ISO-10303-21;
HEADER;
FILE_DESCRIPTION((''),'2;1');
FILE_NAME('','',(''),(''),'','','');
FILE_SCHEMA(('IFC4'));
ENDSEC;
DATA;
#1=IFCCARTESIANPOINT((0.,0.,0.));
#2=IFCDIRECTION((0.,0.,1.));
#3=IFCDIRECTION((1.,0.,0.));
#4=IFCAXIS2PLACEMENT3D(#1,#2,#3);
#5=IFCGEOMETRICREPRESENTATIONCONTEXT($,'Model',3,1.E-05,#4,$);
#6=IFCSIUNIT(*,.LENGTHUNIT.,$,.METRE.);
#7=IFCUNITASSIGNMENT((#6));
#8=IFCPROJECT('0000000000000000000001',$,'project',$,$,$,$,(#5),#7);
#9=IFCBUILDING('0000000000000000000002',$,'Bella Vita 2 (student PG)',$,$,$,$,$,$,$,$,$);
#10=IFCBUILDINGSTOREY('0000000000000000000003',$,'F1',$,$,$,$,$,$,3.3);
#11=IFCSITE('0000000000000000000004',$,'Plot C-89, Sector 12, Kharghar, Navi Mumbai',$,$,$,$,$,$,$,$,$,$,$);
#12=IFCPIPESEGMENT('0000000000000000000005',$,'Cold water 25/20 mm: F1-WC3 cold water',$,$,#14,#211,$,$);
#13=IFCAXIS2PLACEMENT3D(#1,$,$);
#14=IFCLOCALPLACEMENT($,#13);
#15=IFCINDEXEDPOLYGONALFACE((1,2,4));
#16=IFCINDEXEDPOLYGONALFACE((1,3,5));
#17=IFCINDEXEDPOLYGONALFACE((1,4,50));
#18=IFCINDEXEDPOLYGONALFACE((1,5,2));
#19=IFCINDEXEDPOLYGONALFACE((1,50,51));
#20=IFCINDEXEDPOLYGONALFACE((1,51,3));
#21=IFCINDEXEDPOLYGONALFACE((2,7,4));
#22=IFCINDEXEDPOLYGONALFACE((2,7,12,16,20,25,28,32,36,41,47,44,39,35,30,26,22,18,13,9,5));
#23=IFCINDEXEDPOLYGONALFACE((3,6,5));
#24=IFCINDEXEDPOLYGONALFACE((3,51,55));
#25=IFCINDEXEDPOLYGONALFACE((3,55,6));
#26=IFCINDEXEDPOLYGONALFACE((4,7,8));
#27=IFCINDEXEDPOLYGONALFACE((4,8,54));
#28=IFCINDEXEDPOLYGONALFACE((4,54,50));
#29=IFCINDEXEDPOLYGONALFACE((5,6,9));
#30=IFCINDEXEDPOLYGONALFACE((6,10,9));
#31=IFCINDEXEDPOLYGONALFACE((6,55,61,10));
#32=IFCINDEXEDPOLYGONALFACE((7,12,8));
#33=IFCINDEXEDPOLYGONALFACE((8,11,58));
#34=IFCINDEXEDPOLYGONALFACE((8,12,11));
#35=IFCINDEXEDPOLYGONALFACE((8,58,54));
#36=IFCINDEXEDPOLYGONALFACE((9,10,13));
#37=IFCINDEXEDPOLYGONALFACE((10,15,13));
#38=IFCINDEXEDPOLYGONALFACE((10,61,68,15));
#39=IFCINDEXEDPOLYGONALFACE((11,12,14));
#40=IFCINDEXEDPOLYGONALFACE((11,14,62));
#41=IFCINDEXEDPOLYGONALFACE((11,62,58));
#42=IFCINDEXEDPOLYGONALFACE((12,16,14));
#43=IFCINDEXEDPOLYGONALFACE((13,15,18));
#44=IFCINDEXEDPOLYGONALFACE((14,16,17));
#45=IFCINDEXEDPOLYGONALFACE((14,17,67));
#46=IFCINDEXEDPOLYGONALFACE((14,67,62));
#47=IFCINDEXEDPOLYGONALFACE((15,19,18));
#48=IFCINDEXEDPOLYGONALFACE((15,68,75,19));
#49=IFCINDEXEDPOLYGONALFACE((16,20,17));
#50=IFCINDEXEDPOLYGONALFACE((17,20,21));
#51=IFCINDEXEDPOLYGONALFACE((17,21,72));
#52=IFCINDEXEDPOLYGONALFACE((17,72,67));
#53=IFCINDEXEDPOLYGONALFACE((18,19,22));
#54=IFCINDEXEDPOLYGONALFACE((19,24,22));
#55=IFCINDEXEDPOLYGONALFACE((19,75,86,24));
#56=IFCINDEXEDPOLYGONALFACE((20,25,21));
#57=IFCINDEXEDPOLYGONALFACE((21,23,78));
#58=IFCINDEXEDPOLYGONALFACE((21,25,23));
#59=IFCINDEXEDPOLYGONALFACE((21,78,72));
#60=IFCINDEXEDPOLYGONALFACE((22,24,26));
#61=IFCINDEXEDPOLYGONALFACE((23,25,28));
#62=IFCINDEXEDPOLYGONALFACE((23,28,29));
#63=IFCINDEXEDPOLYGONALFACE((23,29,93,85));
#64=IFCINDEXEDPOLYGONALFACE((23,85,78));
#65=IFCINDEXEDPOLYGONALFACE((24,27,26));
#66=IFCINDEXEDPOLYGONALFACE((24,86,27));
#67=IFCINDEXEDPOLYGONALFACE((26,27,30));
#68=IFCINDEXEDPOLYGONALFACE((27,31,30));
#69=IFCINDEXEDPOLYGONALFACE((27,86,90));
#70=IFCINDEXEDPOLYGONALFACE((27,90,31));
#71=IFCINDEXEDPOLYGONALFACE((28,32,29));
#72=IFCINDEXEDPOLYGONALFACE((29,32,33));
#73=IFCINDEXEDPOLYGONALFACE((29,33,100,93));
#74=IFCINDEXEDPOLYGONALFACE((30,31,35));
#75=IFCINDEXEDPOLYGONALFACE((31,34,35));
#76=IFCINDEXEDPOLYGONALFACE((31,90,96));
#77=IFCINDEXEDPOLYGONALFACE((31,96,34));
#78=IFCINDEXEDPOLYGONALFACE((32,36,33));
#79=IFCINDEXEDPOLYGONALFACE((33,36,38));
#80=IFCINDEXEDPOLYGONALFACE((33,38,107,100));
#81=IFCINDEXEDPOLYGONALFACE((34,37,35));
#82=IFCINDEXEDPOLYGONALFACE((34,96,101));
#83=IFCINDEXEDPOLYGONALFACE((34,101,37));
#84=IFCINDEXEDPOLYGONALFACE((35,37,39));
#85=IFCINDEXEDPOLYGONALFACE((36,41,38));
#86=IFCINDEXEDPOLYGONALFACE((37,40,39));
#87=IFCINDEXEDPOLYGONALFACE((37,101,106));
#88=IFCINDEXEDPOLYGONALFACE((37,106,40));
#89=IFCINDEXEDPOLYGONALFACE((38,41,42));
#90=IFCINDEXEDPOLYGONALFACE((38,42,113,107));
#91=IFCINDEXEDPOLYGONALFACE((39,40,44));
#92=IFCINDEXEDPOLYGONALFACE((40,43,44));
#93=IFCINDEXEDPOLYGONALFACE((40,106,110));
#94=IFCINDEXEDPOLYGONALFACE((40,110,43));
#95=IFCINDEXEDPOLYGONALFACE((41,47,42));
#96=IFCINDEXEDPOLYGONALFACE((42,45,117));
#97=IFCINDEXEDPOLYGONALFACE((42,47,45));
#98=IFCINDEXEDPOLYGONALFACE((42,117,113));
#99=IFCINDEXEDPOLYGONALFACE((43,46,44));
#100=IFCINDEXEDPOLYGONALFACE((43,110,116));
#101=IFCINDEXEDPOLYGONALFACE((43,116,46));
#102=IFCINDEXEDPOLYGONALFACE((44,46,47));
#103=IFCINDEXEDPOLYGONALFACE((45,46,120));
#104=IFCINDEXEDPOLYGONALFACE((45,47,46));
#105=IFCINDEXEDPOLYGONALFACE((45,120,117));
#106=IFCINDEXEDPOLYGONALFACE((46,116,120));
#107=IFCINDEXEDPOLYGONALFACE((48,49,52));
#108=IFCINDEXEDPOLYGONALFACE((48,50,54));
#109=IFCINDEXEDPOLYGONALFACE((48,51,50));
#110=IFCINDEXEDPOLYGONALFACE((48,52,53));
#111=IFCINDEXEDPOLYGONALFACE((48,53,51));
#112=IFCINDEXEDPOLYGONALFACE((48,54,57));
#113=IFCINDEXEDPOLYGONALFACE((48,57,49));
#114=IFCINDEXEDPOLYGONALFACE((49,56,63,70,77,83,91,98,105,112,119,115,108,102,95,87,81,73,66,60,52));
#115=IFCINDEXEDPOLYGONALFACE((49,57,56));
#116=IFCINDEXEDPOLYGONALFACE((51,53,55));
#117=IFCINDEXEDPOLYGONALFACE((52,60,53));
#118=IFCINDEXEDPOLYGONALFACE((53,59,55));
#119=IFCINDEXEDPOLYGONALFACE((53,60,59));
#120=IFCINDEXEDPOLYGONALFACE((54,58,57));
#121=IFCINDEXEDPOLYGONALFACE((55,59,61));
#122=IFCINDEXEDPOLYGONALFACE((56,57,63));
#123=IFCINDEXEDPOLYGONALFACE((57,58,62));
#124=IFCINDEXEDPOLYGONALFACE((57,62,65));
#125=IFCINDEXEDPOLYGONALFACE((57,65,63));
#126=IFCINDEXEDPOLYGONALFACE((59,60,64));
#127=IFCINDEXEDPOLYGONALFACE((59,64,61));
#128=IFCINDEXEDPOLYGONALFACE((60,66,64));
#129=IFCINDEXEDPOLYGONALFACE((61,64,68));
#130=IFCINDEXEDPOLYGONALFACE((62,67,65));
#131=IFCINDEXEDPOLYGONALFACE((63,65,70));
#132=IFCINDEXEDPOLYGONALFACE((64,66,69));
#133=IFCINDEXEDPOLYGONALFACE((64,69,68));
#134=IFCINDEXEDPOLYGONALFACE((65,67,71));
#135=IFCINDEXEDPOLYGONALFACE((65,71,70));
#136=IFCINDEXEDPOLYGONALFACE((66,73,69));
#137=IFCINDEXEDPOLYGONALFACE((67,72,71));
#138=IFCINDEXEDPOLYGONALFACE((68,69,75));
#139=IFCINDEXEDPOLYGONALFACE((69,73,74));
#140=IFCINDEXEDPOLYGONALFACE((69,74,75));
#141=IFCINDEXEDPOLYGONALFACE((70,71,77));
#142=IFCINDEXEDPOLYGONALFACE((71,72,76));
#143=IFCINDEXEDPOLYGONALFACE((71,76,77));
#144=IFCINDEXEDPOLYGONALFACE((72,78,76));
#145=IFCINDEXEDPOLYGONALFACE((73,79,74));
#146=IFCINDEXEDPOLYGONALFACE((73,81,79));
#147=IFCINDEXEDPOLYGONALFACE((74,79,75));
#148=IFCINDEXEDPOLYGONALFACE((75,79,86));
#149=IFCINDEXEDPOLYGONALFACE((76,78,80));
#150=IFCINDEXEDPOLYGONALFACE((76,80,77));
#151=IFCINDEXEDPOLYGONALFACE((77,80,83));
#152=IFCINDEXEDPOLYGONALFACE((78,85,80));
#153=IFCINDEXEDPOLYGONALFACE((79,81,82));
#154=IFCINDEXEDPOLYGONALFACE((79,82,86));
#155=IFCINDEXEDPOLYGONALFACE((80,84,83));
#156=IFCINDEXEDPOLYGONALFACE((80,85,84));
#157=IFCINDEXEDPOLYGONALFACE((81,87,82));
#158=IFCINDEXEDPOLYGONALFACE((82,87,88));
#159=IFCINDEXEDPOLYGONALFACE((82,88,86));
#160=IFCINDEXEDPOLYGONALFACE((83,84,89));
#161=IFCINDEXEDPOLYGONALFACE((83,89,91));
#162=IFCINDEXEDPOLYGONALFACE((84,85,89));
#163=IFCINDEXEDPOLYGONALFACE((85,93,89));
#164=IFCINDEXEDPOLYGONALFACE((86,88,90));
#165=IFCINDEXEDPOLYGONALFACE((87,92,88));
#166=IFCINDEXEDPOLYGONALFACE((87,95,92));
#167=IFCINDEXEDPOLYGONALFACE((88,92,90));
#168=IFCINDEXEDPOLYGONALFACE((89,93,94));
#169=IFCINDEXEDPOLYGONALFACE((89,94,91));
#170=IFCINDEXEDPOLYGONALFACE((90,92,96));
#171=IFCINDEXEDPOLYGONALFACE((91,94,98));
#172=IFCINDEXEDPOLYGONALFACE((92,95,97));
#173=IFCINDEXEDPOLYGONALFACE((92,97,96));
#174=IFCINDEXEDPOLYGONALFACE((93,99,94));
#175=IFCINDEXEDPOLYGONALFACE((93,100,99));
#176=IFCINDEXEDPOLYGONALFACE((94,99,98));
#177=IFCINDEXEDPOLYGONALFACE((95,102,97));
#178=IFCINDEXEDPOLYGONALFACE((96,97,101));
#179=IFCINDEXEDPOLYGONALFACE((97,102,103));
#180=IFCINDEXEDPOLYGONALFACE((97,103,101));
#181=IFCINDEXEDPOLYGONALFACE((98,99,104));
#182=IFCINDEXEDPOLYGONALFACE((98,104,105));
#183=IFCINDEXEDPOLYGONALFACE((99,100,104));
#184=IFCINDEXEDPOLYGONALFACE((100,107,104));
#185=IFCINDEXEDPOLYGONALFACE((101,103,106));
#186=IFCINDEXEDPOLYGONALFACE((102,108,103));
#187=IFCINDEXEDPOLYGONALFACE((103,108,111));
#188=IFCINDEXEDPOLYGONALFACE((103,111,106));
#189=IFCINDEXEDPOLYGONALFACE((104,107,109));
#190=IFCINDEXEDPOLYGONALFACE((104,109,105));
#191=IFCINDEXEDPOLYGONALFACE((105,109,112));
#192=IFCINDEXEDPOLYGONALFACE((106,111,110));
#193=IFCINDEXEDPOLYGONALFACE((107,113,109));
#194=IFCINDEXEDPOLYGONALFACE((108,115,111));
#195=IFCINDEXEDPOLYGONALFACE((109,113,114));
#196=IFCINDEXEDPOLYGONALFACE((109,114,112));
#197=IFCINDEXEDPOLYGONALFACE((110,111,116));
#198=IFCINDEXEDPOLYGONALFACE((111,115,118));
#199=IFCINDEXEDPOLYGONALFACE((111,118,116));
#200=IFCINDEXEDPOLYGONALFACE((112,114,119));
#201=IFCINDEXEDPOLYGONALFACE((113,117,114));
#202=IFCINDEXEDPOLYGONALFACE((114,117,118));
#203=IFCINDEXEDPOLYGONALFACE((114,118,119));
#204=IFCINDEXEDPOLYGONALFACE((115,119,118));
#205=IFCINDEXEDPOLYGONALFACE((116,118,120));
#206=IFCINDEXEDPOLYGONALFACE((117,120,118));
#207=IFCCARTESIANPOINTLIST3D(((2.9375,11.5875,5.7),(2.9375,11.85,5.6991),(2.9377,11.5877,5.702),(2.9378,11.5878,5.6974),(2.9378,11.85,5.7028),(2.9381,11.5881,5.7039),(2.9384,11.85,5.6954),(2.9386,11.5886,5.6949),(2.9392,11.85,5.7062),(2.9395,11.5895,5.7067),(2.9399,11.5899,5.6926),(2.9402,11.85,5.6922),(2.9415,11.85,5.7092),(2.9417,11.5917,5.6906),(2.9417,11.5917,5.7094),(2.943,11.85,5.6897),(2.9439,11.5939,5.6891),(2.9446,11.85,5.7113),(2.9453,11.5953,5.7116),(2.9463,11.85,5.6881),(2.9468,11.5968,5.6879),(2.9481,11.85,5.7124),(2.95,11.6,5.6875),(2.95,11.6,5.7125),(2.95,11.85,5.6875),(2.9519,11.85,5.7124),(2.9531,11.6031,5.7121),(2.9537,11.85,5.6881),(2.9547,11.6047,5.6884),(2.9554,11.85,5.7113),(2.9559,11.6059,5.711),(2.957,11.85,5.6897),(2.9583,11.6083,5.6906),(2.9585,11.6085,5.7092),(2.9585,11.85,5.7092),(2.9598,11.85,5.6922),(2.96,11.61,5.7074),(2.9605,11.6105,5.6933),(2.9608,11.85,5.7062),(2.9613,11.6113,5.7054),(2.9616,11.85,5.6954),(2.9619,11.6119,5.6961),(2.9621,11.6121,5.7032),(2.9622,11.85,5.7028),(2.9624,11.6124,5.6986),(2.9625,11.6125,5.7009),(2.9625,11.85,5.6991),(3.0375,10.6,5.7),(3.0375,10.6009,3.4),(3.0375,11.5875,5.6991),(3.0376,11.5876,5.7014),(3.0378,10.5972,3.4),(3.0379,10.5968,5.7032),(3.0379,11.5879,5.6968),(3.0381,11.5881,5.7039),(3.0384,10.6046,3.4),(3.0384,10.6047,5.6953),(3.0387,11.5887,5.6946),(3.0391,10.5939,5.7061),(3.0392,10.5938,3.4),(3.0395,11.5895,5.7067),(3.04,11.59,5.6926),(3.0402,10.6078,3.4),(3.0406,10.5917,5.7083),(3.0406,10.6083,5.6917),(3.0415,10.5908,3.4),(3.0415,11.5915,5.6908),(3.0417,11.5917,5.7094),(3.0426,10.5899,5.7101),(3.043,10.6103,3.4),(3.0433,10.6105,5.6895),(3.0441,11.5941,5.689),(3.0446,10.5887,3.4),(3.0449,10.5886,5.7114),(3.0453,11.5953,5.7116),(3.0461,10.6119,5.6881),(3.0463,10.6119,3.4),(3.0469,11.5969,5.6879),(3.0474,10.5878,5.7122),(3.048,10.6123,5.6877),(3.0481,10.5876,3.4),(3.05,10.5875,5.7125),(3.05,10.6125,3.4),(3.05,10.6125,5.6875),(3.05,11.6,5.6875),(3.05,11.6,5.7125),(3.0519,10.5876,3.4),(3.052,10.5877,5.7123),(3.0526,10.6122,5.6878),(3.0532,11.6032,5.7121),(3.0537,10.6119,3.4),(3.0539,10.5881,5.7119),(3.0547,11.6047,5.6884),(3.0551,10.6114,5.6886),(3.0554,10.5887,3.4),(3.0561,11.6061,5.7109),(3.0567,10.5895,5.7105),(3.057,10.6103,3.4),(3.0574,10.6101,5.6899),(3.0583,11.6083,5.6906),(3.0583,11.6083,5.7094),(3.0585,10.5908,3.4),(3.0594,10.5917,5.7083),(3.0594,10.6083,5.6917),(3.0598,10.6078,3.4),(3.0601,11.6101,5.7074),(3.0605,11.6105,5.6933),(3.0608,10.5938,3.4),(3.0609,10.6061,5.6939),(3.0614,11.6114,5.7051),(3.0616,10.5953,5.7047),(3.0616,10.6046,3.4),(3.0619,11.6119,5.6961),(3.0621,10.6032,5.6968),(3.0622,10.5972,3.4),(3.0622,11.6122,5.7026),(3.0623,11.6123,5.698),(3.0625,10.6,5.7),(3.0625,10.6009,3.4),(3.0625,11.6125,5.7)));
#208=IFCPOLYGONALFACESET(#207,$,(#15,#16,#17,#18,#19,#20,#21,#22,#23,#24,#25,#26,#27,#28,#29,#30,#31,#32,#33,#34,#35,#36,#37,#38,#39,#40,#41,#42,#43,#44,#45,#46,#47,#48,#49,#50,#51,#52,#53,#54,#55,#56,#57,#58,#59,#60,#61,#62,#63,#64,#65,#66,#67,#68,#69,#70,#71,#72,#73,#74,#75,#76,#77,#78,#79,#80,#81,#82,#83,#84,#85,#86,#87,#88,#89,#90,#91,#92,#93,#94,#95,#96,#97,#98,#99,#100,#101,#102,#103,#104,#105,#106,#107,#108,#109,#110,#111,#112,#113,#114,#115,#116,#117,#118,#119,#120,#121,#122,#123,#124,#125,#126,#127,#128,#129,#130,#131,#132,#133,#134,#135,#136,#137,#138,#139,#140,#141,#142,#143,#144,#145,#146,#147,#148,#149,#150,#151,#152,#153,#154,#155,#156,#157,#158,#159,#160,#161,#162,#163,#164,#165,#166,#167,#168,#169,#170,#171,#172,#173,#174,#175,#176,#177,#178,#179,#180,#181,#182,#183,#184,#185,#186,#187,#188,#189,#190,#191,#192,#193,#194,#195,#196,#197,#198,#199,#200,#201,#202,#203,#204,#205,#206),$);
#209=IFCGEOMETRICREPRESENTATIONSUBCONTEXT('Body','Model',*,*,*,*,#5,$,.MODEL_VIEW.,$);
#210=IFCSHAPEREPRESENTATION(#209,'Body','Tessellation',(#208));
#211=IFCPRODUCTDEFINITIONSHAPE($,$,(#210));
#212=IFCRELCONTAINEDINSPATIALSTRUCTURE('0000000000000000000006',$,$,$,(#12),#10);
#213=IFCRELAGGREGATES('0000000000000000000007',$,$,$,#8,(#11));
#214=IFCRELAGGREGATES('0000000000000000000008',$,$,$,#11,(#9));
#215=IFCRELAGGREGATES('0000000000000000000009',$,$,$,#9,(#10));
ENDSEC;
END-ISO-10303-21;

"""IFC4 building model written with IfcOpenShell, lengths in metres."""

from ifc_helpers import new_model, entity, si_unit, origin, origin_with_axes, place, context, subcontext, project, spatial, element, save


model = new_model("IFC4")

# Units and contexts
model_context = context("Model", 3, precision=1e-05, world=origin_with_axes())
body_context = subcontext(model_context, "Body", "Model", "MODEL_VIEW")
ifc_project = project(units=[si_unit("LENGTHUNIT", "METRE")], contexts=[model_context])

# Site, building, storey
site = spatial("IfcSite", under=ifc_project, Name="Plot C-89, Sector 12, Kharghar, Navi Mumbai")
building = spatial("IfcBuilding", under=site, Name="Bella Vita 2 (student PG)")
storey = spatial("IfcBuildingStorey", under=building, Name="F1", Elevation=3.3)

# Pipe segment
pipe_segment_1_placement = place(None, origin())
element("IfcPipeSegment", 1, at=pipe_segment_1_placement, inside=storey, Name="Cold water 25/20 mm: F1-WC3 cold water", context=body_context, shape_type="AdvancedSweptSolid", body=[
    entity("IfcSweptDiskSolid", entity("IfcPolyline", [entity("IfcCartesianPoint", [2.95, 11.85, 5.7]), entity("IfcCartesianPoint", [2.95, 11.6, 5.7]), entity("IfcCartesianPoint", [3.05, 11.6, 5.7]), entity("IfcCartesianPoint", [3.05, 10.6, 5.7]), entity("IfcCartesianPoint", [3.05, 10.6, 3.4])]), 0.0125),
])

save(model, "model.ifc")
